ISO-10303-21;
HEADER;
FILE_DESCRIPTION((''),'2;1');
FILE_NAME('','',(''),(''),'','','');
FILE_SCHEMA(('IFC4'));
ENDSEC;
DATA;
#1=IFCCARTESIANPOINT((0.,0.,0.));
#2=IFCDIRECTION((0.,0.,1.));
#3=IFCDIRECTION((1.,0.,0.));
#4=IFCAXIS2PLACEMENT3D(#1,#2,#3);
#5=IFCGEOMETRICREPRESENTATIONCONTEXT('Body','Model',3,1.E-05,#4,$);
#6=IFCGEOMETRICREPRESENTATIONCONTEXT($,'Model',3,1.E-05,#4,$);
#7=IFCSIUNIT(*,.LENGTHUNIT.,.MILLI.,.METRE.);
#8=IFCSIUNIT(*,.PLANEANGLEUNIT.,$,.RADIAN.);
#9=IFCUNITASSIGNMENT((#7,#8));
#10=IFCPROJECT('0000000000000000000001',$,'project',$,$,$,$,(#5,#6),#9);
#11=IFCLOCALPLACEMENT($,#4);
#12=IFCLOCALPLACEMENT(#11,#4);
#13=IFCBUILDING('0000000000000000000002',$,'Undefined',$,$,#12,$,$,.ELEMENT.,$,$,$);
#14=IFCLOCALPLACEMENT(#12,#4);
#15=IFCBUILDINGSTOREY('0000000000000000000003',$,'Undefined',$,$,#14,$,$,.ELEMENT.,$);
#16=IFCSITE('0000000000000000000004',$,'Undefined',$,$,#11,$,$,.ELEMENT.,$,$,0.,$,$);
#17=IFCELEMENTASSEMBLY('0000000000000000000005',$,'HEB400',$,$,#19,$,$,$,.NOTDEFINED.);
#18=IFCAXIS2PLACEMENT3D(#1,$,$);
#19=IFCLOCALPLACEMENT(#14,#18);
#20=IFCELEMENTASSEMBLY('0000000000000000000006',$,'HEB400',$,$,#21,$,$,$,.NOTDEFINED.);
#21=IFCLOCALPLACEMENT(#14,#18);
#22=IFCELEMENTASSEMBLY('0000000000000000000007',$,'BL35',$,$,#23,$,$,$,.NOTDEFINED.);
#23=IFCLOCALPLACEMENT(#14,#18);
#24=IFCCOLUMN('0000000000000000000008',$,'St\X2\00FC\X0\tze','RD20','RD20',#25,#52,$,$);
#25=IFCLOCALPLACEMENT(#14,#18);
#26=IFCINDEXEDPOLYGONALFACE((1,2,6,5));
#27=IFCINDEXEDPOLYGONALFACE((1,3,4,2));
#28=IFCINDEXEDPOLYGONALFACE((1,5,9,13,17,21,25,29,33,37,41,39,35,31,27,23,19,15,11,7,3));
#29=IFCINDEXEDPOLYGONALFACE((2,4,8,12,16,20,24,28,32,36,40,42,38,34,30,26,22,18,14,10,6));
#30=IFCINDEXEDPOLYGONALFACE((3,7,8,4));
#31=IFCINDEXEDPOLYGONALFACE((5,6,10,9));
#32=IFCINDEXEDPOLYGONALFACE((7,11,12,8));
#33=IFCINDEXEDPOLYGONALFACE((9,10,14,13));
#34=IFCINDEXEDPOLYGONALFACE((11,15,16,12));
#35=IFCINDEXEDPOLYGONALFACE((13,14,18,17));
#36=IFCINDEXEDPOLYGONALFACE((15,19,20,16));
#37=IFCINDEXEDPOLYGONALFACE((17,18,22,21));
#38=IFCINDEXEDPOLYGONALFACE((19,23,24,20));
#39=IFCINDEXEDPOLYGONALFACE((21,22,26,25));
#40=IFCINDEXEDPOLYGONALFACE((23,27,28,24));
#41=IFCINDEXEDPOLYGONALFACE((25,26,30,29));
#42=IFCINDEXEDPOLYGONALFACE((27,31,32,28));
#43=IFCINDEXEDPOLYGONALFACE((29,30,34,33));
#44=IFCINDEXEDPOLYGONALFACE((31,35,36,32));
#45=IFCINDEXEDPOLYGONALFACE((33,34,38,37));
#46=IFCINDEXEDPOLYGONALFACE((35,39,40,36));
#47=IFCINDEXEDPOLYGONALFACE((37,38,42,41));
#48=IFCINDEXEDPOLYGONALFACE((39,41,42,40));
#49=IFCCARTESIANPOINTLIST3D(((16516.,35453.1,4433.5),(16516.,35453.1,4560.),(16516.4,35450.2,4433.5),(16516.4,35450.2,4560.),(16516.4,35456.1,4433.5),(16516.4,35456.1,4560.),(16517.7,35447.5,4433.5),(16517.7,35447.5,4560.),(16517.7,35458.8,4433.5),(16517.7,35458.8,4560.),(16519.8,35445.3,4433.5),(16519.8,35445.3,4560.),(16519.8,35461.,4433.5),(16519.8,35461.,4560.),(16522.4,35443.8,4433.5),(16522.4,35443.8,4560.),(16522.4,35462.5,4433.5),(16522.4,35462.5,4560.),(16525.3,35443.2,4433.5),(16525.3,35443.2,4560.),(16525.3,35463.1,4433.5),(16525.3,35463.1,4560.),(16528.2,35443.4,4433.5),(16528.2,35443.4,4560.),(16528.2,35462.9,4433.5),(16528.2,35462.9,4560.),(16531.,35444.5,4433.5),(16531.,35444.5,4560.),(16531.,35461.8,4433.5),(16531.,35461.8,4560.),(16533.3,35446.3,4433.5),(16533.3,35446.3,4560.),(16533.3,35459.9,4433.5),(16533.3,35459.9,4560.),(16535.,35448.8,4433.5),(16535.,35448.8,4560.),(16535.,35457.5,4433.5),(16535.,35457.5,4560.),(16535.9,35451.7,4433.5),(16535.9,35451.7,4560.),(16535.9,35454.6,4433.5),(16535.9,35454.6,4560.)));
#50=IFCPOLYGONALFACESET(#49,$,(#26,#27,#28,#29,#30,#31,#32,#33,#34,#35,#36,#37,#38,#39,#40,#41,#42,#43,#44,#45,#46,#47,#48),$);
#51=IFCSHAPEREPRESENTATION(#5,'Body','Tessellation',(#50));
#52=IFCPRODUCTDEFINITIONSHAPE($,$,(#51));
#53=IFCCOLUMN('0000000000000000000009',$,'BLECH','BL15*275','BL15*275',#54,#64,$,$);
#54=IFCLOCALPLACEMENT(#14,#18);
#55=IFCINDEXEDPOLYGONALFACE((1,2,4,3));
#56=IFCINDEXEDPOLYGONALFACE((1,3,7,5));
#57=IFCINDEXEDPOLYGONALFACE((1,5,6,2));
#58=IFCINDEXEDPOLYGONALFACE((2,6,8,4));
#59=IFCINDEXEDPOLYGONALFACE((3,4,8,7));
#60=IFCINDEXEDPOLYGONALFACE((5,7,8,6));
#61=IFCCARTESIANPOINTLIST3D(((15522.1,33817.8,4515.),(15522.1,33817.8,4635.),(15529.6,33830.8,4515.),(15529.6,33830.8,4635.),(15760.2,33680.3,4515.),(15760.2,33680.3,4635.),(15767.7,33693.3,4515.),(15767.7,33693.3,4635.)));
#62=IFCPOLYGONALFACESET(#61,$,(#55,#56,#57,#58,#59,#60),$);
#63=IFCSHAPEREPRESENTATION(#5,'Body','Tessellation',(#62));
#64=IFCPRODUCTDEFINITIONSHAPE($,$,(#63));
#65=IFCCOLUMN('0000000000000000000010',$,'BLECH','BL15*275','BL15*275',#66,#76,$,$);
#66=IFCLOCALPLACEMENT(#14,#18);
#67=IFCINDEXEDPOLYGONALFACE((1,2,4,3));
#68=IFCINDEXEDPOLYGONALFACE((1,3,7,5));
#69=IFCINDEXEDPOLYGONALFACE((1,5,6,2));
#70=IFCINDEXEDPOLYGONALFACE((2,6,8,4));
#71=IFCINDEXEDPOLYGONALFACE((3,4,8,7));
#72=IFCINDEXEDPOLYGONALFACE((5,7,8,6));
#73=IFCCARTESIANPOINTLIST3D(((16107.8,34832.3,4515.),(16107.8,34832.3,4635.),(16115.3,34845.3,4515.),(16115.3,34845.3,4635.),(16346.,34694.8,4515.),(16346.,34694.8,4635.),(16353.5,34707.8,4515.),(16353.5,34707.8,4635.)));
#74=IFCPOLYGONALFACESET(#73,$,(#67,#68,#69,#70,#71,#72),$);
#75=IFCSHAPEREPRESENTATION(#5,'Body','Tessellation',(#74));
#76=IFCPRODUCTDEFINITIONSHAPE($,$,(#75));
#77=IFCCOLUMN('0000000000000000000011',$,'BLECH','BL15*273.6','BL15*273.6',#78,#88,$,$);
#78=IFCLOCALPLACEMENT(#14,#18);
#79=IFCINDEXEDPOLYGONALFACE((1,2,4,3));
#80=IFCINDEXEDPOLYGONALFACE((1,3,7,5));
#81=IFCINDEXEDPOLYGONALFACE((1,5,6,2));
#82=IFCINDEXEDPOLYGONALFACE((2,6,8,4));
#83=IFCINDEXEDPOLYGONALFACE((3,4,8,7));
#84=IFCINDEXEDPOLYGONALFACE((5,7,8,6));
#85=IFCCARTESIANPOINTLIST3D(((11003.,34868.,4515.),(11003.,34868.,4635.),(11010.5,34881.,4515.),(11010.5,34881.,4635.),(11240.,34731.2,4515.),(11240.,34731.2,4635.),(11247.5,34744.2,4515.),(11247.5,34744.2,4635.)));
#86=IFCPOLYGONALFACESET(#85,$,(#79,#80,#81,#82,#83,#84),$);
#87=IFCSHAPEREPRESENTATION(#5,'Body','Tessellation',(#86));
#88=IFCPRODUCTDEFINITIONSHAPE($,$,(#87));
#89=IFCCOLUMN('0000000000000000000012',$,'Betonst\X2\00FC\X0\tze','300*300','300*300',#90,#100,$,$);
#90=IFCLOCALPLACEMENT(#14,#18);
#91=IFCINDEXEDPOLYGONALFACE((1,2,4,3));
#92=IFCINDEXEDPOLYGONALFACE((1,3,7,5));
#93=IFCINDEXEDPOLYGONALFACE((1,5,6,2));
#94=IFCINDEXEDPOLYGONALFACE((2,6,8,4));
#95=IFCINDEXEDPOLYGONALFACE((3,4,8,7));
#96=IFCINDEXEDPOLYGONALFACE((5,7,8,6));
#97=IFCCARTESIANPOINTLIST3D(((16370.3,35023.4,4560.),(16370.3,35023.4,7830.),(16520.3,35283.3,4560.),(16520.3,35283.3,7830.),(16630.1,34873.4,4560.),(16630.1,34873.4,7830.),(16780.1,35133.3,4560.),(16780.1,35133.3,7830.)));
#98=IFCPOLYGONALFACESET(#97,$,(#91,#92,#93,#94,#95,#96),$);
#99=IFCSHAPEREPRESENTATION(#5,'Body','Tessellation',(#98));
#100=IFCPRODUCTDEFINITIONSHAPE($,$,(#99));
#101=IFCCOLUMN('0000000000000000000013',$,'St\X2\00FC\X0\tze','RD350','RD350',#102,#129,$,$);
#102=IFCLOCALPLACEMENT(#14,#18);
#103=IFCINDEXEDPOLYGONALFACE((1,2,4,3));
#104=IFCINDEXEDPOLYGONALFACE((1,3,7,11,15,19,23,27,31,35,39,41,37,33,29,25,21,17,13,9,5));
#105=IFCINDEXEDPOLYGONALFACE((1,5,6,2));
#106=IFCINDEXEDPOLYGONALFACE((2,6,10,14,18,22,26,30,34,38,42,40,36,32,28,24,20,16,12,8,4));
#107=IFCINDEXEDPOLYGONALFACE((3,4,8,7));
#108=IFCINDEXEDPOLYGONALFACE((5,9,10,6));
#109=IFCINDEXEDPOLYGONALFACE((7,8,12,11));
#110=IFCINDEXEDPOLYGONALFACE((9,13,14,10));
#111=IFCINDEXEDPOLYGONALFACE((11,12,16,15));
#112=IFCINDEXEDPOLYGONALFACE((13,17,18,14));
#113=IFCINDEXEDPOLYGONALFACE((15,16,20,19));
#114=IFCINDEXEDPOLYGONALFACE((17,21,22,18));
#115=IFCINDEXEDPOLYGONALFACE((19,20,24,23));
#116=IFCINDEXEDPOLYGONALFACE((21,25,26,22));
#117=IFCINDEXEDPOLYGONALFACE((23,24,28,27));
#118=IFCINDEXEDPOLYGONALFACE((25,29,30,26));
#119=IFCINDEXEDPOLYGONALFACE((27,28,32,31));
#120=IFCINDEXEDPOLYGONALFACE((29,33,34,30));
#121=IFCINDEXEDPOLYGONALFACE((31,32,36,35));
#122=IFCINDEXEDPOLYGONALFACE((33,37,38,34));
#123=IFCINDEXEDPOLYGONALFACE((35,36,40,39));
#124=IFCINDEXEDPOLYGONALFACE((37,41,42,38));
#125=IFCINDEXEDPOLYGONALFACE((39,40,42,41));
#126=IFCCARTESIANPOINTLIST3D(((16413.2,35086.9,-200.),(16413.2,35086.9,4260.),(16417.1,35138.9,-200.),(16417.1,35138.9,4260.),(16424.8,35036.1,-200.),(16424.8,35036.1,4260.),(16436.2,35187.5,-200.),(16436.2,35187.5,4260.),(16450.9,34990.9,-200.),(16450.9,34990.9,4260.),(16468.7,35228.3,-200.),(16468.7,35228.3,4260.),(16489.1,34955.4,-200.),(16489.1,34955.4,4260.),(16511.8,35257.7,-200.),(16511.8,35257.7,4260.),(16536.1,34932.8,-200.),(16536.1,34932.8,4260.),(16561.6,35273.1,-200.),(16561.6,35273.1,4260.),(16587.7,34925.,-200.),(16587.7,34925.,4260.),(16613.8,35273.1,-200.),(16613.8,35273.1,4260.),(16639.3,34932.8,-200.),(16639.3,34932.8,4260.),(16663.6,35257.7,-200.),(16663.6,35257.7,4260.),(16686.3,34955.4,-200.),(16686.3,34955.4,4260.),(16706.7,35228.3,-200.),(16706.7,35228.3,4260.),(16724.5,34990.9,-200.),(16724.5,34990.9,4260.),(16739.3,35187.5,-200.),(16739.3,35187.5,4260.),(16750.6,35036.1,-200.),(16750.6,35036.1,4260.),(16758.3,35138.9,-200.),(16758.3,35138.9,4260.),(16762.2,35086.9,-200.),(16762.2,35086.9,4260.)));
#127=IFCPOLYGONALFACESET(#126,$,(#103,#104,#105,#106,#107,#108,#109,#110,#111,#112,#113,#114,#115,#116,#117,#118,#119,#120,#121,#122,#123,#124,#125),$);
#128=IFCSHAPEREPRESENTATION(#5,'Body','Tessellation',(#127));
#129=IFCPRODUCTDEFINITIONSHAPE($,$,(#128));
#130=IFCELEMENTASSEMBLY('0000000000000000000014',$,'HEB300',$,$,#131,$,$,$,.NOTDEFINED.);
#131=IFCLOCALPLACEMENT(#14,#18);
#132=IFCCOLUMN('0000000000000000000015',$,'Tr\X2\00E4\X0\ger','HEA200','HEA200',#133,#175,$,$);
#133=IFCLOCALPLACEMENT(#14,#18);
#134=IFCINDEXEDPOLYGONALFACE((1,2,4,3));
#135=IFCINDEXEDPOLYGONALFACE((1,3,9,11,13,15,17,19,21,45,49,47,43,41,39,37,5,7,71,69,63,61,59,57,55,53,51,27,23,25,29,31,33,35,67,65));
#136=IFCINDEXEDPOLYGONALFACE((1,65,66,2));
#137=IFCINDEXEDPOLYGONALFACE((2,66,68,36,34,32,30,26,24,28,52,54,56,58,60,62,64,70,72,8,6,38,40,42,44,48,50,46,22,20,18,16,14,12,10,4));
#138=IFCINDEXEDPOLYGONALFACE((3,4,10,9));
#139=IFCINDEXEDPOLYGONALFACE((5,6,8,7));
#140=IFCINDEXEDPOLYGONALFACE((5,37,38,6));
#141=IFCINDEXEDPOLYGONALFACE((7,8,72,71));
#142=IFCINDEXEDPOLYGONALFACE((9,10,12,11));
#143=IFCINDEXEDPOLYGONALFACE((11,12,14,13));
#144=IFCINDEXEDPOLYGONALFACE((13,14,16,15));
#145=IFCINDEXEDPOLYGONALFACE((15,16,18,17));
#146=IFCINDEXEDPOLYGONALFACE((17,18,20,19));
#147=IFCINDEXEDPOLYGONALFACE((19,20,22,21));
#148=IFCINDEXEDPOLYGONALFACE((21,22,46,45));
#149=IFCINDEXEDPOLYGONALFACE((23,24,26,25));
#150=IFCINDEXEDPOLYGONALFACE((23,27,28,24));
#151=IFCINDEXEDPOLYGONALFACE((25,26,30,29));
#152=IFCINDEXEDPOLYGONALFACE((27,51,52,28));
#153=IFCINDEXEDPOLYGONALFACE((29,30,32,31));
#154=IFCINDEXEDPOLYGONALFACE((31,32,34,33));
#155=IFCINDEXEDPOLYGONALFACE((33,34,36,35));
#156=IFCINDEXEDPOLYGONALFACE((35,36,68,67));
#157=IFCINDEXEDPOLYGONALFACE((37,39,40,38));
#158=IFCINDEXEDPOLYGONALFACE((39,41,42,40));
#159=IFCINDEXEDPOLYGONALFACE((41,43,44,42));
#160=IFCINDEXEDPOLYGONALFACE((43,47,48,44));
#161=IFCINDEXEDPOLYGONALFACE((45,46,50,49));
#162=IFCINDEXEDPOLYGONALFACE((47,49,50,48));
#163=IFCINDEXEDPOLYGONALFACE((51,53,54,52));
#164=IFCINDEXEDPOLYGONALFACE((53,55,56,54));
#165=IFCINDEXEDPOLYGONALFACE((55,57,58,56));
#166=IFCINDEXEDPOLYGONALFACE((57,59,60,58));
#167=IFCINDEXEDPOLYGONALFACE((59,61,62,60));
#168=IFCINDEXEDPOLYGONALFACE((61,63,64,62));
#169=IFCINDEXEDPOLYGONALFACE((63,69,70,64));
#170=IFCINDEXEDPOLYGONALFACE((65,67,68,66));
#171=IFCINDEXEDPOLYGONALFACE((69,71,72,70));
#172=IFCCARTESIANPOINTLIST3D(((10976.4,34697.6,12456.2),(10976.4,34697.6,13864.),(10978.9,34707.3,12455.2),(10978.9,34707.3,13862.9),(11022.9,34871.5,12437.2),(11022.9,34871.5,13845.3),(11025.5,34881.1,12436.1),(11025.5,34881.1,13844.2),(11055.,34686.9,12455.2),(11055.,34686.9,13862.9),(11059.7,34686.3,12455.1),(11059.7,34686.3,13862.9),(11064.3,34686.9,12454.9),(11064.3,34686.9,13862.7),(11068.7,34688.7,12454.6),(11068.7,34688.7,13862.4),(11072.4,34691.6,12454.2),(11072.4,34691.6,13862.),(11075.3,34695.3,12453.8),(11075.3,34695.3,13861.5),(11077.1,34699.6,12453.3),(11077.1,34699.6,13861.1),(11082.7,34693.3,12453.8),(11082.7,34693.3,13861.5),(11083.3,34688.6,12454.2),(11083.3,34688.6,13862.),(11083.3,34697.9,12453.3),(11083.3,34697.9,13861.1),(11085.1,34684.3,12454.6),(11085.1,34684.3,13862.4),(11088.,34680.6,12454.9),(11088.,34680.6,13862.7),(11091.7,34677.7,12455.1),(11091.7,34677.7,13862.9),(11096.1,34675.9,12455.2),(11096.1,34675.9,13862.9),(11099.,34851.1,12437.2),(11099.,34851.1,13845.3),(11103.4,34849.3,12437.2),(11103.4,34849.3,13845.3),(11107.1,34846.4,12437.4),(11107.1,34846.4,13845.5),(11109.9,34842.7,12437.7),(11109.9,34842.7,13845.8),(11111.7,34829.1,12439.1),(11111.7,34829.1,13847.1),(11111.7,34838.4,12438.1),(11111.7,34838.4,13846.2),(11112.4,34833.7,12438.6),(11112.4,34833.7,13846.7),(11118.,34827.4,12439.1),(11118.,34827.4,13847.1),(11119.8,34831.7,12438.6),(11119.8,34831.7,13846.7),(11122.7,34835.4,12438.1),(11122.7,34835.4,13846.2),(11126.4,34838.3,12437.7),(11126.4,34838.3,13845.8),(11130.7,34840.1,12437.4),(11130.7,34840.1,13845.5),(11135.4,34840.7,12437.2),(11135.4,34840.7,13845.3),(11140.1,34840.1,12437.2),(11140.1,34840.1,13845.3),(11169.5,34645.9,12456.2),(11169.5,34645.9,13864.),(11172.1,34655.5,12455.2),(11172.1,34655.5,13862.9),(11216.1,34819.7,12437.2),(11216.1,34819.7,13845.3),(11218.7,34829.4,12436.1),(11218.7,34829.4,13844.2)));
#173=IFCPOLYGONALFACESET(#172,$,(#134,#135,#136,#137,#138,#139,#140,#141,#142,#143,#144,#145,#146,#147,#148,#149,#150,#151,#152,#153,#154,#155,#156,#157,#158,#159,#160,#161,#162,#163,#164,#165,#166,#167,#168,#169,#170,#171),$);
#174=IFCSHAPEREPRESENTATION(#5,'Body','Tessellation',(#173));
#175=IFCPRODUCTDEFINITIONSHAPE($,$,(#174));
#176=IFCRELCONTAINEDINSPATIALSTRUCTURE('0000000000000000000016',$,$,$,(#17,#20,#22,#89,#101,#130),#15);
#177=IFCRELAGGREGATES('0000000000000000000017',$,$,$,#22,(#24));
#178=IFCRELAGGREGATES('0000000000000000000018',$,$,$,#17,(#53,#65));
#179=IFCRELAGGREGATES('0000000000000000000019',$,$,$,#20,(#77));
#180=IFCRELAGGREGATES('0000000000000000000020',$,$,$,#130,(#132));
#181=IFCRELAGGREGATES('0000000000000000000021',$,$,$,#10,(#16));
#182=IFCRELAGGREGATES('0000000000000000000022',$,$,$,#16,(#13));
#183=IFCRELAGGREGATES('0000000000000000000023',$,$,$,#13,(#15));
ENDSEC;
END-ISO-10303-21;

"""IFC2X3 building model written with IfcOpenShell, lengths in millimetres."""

from ifc_helpers import new_model, si_unit, frame, origin_with_axes, origin_2d_with_axis, place, context, project, spatial, rectangle, circle, i_section, extrude, clip, halfspace, element, aggregate, save


model = new_model("IFC2X3")

# Units and contexts
model_context_1 = context("Model", 3, precision=1e-05, world=origin_with_axes(), identifier="Body")
model_context_2 = context("Model", 3, precision=1e-05, world=origin_with_axes())
ifc_project = project(units=[si_unit("LENGTHUNIT", "METRE", prefix="MILLI"), si_unit("PLANEANGLEUNIT", "RADIAN")], contexts=[model_context_1, model_context_2])

# Site, building, storey
site_placement = place(None, origin_with_axes())
site = spatial("IfcSite", under=ifc_project, at=site_placement, Name="Undefined", CompositionType="ELEMENT", RefElevation=0.0)
building_placement = place(site_placement, origin_with_axes())
building = spatial("IfcBuilding", under=site, at=building_placement, Name="Undefined", CompositionType="ELEMENT")
storey_placement = place(building_placement, origin_with_axes())
storey = spatial("IfcBuildingStorey", under=building, at=storey_placement, Name="Undefined", CompositionType="ELEMENT")

# Element assembly
assembly_1 = element("IfcElementAssembly", 1, inside=storey, Name="HEB400", PredefinedType="NOTDEFINED")

# Element assembly
assembly_2 = element("IfcElementAssembly", 2, inside=storey, Name="HEB400", PredefinedType="NOTDEFINED")

# Element assembly, column
assembly_3 = element("IfcElementAssembly", 3, inside=storey, Name="BL35", PredefinedType="NOTDEFINED")
column_1_placement = place(storey_placement, frame((16526.0, 35453.1, 4433.5), z_axis=(0.0, 0.0, 1.0), x_axis=(1.0, 0.0, 0.0)))
column_1 = element("IfcColumn", 4, at=column_1_placement, Name="Stütze", Description="RD20", ObjectType="RD20", context=model_context_1, shape_type="SweptSolid", body=[
    extrude(circle(Radius=10.0, at=origin_2d_with_axis()), frame((0.0, 0.0, 126.5), z_axis=(0.0, 0.0, -1.0), x_axis=(0.5, 0.866025, 0.0)), (0.0, 0.0, 1.0), 126.5),
])
aggregate(assembly_3, [column_1])

# Columns
column_2_placement = place(storey_placement, frame((15644.9, 33755.5, 4515.0), z_axis=(0.0, 0.0, 1.0), x_axis=(1.0, 0.0, 0.0)))
column_2 = element("IfcColumn", 5, at=column_2_placement, Name="BLECH", Description="BL15*275", ObjectType="BL15*275", context=model_context_1, shape_type="SweptSolid", body=[
    extrude(rectangle(XDim=15.0, YDim=275.0, at=origin_2d_with_axis()), frame((0.0, 0.0, 120.0), z_axis=(0.0, 0.0, -1.0), x_axis=(0.5, 0.866025, 0.0)), (0.0, 0.0, 1.0), 120.0),
])
column_3_placement = place(storey_placement, frame((16230.7, 34770.1, 4515.0), z_axis=(0.0, 0.0, 1.0), x_axis=(1.0, 0.0, 0.0)))
column_3 = element("IfcColumn", 6, at=column_3_placement, Name="BLECH", Description="BL15*275", ObjectType="BL15*275", context=model_context_1, shape_type="SweptSolid", body=[
    extrude(rectangle(XDim=15.0, YDim=275.0, at=origin_2d_with_axis()), frame((0.0, 0.0, 120.0), z_axis=(0.0, 0.0, -1.0), x_axis=(0.5, 0.866025, 0.0)), (0.0, 0.0, 1.0), 120.0),
])
aggregate(assembly_1, [column_2, column_3])
column_4_placement = place(storey_placement, frame((11125.3, 34806.1, 4515.0), z_axis=(0.0, 0.0, 1.0), x_axis=(1.0, 0.0, 0.0)))
column_4 = element("IfcColumn", 7, at=column_4_placement, Name="BLECH", Description="BL15*273.6", ObjectType="BL15*273.6", context=model_context_1, shape_type="SweptSolid", body=[
    extrude(rectangle(XDim=15.0, YDim=273.6, at=origin_2d_with_axis()), frame((0.0, 0.0, 120.0), z_axis=(0.0, 0.0, -1.0), x_axis=(-0.500001, -0.866025, 0.0)), (0.0, 0.0, 1.0), 120.0),
])
aggregate(assembly_2, [column_4])

# Columns
column_5_placement = place(storey_placement, frame((16575.2, 35078.3, 4560.0), z_axis=(0.0, 0.0, 1.0), x_axis=(1.0, 0.0, 0.0)))
element("IfcColumn", 8, at=column_5_placement, inside=storey, Name="Betonstütze", Description="300*300", ObjectType="300*300", context=model_context_1, shape_type="SweptSolid", body=[
    extrude(rectangle(XDim=300.0, YDim=300.0, at=origin_2d_with_axis()), frame((0.0, 0.0, 3270.0), z_axis=(0.0, 0.0, -1.0), x_axis=(0.866025, -0.5, 0.0)), (0.0, 0.0, 1.0), 3270.0),
])
column_6_placement = place(storey_placement, frame((16587.7, 35100.0, -200.0), z_axis=(0.0, 0.0, 1.0), x_axis=(1.0, 0.0, 0.0)))
element("IfcColumn", 9, at=column_6_placement, inside=storey, Name="Stütze", Description="RD350", ObjectType="RD350", context=model_context_1, shape_type="SweptSolid", body=[
    extrude(circle(Radius=175.0, at=origin_2d_with_axis()), frame((0.0, 0.0, 4460.0), z_axis=(0.0, 0.0, -1.0), x_axis=(-0.866025, 0.500001, 0.0)), (0.0, 0.0, 1.0), 4460.0),
])

# Element assembly, column
assembly_4 = element("IfcElementAssembly", 10, inside=storey, Name="HEB300", PredefinedType="NOTDEFINED")
column_7_placement = place(storey_placement, frame((11097.5, 34763.5, 12295.6), z_axis=(0.0, 0.0, 1.0), x_axis=(1.0, 0.0, 0.0)))
column_7 = element("IfcColumn", 11, at=column_7_placement, Name="Träger", Description="HEA200", ObjectType="HEA200", context=model_context_1, shape_type="Clipping", body=[
    clip(clip(extrude(i_section(OverallWidth=200.0, OverallDepth=190.0, WebThickness=6.5, FlangeThickness=10.0, FilletRadius=18.0, at=origin_2d_with_axis()), frame((0.0, 0.0, 1578.6), z_axis=(0.0, 0.0, -1.0), x_axis=(0.965926, -0.258819, 0.0)), (0.0, 0.0, 1.0), 1448.2), halfspace(frame((24.6, 91.8, 1548.6), z_axis=(-0.026748, -0.099826, -0.994645), x_axis=(-0.257433, -0.960754, 0.103347)), True)), halfspace(frame((0.0, 0.0, 150.6), z_axis=(-0.027262, -0.101742, -0.994437), x_axis=(-0.257379, -0.960553, 0.105331)), False)),
])
aggregate(assembly_4, [column_7])

save(model, "model.ifc")
